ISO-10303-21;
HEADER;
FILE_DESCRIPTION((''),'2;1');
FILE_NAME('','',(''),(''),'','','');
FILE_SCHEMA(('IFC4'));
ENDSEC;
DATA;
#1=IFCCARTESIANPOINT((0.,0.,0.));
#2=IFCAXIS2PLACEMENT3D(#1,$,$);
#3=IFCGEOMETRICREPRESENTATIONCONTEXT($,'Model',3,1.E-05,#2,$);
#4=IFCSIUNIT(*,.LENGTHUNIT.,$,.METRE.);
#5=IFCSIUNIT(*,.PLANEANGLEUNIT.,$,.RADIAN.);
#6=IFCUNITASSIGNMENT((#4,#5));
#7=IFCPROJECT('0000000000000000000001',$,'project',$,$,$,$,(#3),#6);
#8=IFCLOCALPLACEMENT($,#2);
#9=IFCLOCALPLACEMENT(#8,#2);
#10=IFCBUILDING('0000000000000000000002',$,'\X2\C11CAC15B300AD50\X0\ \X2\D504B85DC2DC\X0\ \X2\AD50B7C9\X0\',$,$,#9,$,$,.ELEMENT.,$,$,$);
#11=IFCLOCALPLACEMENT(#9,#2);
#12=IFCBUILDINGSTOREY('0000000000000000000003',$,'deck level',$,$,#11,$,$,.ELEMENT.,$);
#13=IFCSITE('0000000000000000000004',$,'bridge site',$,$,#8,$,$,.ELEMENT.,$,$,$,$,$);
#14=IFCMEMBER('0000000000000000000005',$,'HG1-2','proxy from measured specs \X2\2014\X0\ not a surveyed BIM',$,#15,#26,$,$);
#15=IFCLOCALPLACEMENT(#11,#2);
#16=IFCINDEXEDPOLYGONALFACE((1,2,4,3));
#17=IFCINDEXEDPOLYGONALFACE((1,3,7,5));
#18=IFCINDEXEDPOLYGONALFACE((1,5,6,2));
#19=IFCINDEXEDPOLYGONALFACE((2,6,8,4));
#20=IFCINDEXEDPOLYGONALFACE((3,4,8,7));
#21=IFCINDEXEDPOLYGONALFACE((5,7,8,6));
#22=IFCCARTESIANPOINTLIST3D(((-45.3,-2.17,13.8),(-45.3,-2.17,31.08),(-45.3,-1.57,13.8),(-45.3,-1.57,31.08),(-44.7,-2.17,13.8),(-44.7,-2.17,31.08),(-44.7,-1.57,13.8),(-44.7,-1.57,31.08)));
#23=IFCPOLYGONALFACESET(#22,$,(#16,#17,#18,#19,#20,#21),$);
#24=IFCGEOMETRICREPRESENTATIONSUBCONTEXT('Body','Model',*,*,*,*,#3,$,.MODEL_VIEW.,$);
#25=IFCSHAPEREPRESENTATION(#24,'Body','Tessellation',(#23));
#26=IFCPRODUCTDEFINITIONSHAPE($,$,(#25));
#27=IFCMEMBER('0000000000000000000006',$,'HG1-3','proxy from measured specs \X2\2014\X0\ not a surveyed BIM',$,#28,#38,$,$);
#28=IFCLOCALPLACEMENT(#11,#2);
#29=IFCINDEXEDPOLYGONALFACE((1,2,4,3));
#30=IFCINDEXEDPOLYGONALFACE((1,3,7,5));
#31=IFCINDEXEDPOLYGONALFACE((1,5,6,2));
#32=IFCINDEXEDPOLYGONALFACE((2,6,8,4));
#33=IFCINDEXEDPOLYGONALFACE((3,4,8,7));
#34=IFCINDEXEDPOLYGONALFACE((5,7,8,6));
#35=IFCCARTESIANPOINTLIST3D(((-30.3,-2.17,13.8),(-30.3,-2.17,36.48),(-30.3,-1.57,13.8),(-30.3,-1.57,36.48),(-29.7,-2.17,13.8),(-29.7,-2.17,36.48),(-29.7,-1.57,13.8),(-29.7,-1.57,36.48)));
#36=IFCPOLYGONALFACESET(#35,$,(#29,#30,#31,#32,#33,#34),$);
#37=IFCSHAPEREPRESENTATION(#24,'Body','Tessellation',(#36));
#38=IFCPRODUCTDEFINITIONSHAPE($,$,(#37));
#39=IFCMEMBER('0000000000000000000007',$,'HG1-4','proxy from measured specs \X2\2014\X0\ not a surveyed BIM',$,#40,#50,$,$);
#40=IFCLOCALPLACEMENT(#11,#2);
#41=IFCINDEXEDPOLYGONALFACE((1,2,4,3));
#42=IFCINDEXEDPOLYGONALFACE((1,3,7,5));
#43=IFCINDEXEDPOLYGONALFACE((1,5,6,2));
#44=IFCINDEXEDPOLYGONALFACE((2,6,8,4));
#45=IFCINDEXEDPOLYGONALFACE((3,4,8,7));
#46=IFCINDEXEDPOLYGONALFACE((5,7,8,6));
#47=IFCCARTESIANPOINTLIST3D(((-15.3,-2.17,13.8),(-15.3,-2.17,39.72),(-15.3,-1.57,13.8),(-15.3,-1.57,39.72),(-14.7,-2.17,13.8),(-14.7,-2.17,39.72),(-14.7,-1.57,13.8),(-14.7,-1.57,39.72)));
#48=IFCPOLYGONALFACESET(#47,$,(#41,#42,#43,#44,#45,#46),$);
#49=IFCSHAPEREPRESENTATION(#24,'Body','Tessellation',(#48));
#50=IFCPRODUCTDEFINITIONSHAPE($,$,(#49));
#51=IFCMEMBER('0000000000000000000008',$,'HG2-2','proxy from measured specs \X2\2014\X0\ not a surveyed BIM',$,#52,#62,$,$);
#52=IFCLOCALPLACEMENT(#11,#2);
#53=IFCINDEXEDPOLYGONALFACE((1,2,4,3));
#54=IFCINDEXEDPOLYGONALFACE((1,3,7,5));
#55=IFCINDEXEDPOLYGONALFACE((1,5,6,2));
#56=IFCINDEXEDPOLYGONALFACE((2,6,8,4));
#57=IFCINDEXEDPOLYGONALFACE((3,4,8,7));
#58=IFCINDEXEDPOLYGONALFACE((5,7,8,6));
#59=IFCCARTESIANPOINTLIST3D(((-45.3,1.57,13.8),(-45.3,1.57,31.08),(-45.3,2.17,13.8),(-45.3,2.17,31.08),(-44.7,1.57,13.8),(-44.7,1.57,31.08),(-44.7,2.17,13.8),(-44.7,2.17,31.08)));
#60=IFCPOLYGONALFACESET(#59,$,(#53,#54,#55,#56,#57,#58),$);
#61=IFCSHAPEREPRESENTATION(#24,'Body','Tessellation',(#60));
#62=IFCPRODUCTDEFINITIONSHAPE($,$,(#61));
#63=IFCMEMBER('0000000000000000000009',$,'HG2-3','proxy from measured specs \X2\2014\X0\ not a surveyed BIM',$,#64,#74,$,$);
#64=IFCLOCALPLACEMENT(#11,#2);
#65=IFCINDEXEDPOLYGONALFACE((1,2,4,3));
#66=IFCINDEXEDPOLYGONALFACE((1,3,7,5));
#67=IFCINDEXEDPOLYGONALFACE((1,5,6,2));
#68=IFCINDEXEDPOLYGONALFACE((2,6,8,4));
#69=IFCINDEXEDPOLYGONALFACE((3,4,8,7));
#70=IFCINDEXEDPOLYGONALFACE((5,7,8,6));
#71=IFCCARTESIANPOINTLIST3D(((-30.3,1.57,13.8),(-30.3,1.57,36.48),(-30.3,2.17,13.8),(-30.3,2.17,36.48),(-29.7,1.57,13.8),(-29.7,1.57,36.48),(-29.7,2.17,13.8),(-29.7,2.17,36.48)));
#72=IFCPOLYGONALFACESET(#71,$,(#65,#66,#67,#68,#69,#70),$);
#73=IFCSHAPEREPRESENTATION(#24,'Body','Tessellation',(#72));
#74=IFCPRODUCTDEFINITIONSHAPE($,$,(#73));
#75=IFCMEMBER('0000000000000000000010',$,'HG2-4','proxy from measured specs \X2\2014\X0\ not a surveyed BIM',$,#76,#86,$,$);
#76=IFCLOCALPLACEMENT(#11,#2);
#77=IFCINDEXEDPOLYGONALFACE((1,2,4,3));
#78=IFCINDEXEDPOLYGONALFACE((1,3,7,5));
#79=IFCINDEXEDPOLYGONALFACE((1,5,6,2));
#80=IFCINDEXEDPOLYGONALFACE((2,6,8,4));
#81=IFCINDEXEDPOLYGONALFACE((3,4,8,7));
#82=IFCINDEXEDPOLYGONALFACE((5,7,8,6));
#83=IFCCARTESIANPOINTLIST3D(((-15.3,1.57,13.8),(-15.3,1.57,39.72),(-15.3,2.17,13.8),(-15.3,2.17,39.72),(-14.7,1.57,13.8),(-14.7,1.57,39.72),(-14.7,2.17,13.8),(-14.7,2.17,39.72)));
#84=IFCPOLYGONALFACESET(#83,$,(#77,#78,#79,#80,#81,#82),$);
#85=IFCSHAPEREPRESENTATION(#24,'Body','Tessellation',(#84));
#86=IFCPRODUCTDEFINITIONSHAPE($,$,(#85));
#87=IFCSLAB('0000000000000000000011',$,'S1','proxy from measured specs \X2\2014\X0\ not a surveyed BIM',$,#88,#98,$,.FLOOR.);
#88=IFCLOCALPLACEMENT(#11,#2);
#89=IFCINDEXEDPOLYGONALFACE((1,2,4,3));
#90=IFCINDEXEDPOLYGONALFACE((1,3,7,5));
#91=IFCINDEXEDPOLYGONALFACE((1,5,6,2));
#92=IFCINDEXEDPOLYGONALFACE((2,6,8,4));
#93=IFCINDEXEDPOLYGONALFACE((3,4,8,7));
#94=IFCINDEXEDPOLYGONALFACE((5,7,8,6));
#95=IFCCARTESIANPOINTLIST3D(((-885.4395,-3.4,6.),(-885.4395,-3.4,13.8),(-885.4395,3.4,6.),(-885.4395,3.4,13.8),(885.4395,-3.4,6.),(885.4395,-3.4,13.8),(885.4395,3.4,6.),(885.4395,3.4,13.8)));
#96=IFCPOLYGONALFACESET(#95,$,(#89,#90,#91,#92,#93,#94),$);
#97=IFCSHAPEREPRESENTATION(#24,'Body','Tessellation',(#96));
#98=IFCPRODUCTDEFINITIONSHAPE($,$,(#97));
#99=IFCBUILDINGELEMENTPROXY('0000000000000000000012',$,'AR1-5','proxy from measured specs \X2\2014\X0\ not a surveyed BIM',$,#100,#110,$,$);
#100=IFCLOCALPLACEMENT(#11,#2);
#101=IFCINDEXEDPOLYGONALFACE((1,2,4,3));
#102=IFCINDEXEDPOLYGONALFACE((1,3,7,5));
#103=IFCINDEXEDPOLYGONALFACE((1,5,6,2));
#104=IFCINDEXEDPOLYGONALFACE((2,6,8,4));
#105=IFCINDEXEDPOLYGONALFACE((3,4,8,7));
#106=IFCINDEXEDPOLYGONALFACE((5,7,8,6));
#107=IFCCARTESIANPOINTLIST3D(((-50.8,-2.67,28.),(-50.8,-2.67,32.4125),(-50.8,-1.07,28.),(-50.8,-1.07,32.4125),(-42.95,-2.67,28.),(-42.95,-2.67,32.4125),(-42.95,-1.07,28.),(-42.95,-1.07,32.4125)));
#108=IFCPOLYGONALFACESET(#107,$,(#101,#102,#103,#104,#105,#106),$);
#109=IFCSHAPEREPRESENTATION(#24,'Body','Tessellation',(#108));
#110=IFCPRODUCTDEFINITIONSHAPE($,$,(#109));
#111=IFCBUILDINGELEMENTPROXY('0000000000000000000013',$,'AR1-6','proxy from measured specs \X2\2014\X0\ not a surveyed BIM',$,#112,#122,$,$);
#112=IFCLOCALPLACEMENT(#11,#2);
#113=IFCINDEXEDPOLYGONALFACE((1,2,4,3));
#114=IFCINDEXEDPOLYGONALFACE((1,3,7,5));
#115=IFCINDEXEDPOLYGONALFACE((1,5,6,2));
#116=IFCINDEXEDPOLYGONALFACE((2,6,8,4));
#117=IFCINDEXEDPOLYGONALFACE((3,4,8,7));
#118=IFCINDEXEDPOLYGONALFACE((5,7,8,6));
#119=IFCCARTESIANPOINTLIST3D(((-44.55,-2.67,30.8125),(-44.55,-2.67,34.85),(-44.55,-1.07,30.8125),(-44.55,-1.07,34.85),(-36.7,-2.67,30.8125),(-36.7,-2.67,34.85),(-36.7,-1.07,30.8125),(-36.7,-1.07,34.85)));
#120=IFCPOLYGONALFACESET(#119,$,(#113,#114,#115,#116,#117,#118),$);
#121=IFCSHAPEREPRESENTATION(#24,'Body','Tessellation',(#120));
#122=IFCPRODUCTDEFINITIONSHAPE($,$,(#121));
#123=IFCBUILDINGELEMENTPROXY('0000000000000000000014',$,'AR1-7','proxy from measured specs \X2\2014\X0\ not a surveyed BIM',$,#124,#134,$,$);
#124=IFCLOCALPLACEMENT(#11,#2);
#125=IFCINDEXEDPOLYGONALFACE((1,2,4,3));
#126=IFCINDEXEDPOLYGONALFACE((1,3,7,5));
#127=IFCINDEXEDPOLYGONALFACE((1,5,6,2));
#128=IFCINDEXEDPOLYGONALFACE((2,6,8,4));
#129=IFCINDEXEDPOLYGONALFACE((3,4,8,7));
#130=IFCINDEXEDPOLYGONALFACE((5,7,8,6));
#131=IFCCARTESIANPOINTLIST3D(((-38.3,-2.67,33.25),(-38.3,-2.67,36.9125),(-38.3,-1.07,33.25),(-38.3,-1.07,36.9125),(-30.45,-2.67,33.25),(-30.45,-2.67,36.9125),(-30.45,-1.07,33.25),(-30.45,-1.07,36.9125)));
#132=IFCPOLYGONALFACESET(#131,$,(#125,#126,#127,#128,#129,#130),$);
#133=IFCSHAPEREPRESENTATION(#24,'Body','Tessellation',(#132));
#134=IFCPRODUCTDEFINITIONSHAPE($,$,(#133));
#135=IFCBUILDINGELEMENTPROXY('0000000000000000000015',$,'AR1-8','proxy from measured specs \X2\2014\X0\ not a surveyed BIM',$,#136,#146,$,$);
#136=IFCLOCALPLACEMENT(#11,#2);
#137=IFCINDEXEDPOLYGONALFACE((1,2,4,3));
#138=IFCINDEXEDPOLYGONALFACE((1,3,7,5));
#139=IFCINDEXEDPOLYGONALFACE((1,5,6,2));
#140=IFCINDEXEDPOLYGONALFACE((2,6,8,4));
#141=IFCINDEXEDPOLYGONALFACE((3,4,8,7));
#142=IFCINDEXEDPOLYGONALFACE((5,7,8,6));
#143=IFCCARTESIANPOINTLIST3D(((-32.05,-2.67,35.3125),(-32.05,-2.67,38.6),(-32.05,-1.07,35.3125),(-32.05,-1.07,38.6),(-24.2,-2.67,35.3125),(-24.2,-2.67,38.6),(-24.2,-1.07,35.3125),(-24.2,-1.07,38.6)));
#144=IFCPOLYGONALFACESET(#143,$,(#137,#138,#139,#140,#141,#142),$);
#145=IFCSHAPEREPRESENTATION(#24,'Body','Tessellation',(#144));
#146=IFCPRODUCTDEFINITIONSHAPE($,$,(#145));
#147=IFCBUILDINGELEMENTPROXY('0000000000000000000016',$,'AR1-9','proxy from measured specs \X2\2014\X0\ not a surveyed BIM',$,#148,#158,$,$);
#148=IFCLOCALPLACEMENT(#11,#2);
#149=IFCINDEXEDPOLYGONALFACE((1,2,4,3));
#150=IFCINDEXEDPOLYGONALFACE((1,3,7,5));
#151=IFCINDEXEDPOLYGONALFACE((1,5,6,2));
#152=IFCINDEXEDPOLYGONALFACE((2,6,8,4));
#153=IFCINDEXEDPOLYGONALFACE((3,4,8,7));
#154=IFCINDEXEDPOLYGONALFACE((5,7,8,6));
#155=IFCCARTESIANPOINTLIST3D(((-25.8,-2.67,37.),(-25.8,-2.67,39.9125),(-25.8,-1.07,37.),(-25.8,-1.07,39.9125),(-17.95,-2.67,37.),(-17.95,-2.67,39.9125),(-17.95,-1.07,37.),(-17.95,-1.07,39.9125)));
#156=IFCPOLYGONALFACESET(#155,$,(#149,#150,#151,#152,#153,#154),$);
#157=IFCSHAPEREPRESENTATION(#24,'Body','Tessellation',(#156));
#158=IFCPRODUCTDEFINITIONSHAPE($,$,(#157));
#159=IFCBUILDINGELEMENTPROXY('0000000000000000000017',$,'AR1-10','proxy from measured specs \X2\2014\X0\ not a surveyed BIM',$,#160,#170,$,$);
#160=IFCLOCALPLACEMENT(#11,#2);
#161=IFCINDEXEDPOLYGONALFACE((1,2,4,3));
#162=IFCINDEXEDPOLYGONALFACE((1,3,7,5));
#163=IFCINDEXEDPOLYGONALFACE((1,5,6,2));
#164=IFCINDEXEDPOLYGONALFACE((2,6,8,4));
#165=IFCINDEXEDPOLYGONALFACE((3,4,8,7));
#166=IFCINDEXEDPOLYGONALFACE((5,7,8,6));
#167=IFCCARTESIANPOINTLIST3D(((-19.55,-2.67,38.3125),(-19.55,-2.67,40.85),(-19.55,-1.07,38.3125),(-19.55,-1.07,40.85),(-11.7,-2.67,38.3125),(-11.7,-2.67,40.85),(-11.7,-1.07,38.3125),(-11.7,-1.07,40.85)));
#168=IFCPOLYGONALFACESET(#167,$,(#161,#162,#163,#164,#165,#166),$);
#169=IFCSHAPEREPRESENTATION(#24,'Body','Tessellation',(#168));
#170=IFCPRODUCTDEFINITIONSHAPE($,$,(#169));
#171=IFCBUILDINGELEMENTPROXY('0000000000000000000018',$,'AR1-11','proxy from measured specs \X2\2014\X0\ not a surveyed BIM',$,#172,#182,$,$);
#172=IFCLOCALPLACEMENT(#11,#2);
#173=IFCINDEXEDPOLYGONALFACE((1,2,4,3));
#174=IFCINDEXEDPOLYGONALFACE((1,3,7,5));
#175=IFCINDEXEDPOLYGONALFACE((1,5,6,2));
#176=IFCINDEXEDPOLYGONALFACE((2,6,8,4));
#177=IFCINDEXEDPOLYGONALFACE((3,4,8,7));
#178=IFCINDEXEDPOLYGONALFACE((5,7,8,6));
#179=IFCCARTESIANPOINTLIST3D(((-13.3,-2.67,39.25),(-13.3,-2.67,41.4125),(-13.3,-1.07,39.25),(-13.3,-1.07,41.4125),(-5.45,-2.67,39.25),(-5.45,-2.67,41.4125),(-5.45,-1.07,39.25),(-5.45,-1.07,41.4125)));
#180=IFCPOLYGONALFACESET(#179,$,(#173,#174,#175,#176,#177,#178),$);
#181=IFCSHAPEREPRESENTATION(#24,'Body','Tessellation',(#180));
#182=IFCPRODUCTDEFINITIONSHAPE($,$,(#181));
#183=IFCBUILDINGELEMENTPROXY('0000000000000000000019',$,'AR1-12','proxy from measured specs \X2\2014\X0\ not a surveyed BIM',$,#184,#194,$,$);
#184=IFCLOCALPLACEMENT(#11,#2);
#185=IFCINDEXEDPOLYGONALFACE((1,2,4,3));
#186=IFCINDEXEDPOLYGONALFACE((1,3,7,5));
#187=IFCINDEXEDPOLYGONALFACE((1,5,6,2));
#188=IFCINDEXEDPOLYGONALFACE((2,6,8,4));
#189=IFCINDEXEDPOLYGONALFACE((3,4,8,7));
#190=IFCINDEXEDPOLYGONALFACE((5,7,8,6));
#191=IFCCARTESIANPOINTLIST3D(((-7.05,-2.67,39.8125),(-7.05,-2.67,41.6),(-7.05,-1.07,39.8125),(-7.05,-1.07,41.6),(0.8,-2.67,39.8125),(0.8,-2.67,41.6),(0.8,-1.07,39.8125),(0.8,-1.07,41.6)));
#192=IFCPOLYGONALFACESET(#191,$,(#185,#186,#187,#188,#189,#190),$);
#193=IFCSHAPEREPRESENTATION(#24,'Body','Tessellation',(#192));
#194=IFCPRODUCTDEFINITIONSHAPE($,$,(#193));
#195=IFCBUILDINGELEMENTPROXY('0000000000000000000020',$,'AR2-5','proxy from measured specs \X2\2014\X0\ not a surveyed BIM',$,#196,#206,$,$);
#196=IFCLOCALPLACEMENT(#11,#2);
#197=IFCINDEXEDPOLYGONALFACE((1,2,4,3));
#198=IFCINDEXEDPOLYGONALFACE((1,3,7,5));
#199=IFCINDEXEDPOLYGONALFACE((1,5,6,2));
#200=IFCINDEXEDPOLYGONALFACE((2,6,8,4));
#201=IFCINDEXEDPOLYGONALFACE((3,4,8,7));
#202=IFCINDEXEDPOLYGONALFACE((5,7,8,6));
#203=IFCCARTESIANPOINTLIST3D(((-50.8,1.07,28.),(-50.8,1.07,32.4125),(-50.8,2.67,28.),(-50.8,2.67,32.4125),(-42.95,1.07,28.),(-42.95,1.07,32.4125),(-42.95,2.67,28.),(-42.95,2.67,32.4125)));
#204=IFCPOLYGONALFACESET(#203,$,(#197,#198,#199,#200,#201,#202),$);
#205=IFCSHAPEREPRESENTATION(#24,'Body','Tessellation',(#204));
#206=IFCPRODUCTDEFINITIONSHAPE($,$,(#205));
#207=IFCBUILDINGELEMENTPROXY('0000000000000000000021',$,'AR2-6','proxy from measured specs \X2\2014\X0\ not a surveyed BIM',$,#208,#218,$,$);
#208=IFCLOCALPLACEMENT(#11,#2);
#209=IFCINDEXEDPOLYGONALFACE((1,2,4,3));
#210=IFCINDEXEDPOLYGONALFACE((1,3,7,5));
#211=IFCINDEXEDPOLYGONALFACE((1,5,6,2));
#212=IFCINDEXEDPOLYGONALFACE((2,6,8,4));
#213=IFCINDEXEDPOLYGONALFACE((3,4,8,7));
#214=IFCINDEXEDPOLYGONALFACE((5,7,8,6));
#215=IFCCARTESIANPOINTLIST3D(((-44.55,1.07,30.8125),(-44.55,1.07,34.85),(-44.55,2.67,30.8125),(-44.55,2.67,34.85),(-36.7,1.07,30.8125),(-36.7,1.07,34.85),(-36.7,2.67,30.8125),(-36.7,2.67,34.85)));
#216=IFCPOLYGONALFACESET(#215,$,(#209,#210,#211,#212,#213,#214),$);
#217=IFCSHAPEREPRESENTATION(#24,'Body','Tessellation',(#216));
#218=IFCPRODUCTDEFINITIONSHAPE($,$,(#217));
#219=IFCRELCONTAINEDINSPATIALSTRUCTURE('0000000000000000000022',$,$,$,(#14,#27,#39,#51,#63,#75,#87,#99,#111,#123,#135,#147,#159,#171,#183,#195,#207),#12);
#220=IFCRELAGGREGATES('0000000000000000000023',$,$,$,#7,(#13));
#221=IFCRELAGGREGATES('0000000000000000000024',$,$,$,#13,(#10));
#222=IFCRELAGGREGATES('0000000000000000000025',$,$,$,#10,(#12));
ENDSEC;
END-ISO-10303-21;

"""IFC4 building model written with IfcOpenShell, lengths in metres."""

from ifc_helpers import new_model, si_unit, frame, origin, origin_2d, place, context, subcontext, project, spatial, rectangle, extrude, element, save


model = new_model("IFC4")

# Units and contexts
model_context = context("Model", 3, precision=1e-05, world=origin())
body_context = subcontext(model_context, "Body", "Model", "MODEL_VIEW")
ifc_project = project(units=[si_unit("LENGTHUNIT", "METRE"), si_unit("PLANEANGLEUNIT", "RADIAN")], contexts=[model_context])

# Site, building, storey
site_placement = place(None, origin())
site = spatial("IfcSite", under=ifc_project, at=site_placement, Name="bridge site", CompositionType="ELEMENT")
building_placement = place(site_placement, origin())
building = spatial("IfcBuilding", under=site, at=building_placement, Name="서강대교 프록시 교량", CompositionType="ELEMENT")
storey_placement = place(building_placement, origin())
storey = spatial("IfcBuildingStorey", under=building, at=storey_placement, Name="deck level", CompositionType="ELEMENT")

# Members
member_1_placement = place(storey_placement, frame((-45.0, -1.87, 13.8)))
element("IfcMember", 1, at=member_1_placement, inside=storey, Name="HG1-2", Description="proxy from measured specs — not a surveyed BIM", context=body_context, shape_type="SweptSolid", body=[
    extrude(rectangle(XDim=0.6, YDim=0.6, at=origin_2d()), origin(), (0.0, 0.0, 1.0), 17.28),
])
member_2_placement = place(storey_placement, frame((-30.0, -1.87, 13.8)))
element("IfcMember", 2, at=member_2_placement, inside=storey, Name="HG1-3", Description="proxy from measured specs — not a surveyed BIM", context=body_context, shape_type="SweptSolid", body=[
    extrude(rectangle(XDim=0.6, YDim=0.6, at=origin_2d()), origin(), (0.0, 0.0, 1.0), 22.68),
])
member_3_placement = place(storey_placement, frame((-15.0, -1.87, 13.8)))
element("IfcMember", 3, at=member_3_placement, inside=storey, Name="HG1-4", Description="proxy from measured specs — not a surveyed BIM", context=body_context, shape_type="SweptSolid", body=[
    extrude(rectangle(XDim=0.6, YDim=0.6, at=origin_2d()), origin(), (0.0, 0.0, 1.0), 25.92),
])
member_4_placement = place(storey_placement, frame((-45.0, 1.87, 13.8)))
element("IfcMember", 4, at=member_4_placement, inside=storey, Name="HG2-2", Description="proxy from measured specs — not a surveyed BIM", context=body_context, shape_type="SweptSolid", body=[
    extrude(rectangle(XDim=0.6, YDim=0.6, at=origin_2d()), origin(), (0.0, 0.0, 1.0), 17.28),
])
member_5_placement = place(storey_placement, frame((-30.0, 1.87, 13.8)))
element("IfcMember", 5, at=member_5_placement, inside=storey, Name="HG2-3", Description="proxy from measured specs — not a surveyed BIM", context=body_context, shape_type="SweptSolid", body=[
    extrude(rectangle(XDim=0.6, YDim=0.6, at=origin_2d()), origin(), (0.0, 0.0, 1.0), 22.68),
])
member_6_placement = place(storey_placement, frame((-15.0, 1.87, 13.8)))
element("IfcMember", 6, at=member_6_placement, inside=storey, Name="HG2-4", Description="proxy from measured specs — not a surveyed BIM", context=body_context, shape_type="SweptSolid", body=[
    extrude(rectangle(XDim=0.6, YDim=0.6, at=origin_2d()), origin(), (0.0, 0.0, 1.0), 25.92),
])

# Slab
slab_placement = place(storey_placement, frame((0.0, 0.0, 6.0)))
element("IfcSlab", 7, at=slab_placement, inside=storey, Name="S1", Description="proxy from measured specs — not a surveyed BIM", PredefinedType="FLOOR", context=body_context, shape_type="SweptSolid", body=[
    extrude(rectangle(XDim=1770.8791, YDim=6.8, at=origin_2d()), origin(), (0.0, 0.0, 1.0), 7.8),
])

# Building element proxies
proxy_1_placement = place(storey_placement, frame((-46.875, -1.87, 28.0)))
element("IfcBuildingElementProxy", 8, at=proxy_1_placement, inside=storey, Name="AR1-5", Description="proxy from measured specs — not a surveyed BIM", context=body_context, shape_type="SweptSolid", body=[
    extrude(rectangle(XDim=7.85, YDim=1.6, at=origin_2d()), origin(), (0.0, 0.0, 1.0), 4.4125),
])
proxy_2_placement = place(storey_placement, frame((-40.625, -1.87, 30.8125)))
element("IfcBuildingElementProxy", 9, at=proxy_2_placement, inside=storey, Name="AR1-6", Description="proxy from measured specs — not a surveyed BIM", context=body_context, shape_type="SweptSolid", body=[
    extrude(rectangle(XDim=7.85, YDim=1.6, at=origin_2d()), origin(), (0.0, 0.0, 1.0), 4.0375),
])
proxy_3_placement = place(storey_placement, frame((-34.375, -1.87, 33.25)))
element("IfcBuildingElementProxy", 10, at=proxy_3_placement, inside=storey, Name="AR1-7", Description="proxy from measured specs — not a surveyed BIM", context=body_context, shape_type="SweptSolid", body=[
    extrude(rectangle(XDim=7.85, YDim=1.6, at=origin_2d()), origin(), (0.0, 0.0, 1.0), 3.6625),
])
proxy_4_placement = place(storey_placement, frame((-28.125, -1.87, 35.3125)))
element("IfcBuildingElementProxy", 11, at=proxy_4_placement, inside=storey, Name="AR1-8", Description="proxy from measured specs — not a surveyed BIM", context=body_context, shape_type="SweptSolid", body=[
    extrude(rectangle(XDim=7.85, YDim=1.6, at=origin_2d()), origin(), (0.0, 0.0, 1.0), 3.2875),
])
proxy_5_placement = place(storey_placement, frame((-21.875, -1.87, 37.0)))
element("IfcBuildingElementProxy", 12, at=proxy_5_placement, inside=storey, Name="AR1-9", Description="proxy from measured specs — not a surveyed BIM", context=body_context, shape_type="SweptSolid", body=[
    extrude(rectangle(XDim=7.85, YDim=1.6, at=origin_2d()), origin(), (0.0, 0.0, 1.0), 2.9125),
])
proxy_6_placement = place(storey_placement, frame((-15.625, -1.87, 38.3125)))
element("IfcBuildingElementProxy", 13, at=proxy_6_placement, inside=storey, Name="AR1-10", Description="proxy from measured specs — not a surveyed BIM", context=body_context, shape_type="SweptSolid", body=[
    extrude(rectangle(XDim=7.85, YDim=1.6, at=origin_2d()), origin(), (0.0, 0.0, 1.0), 2.5375),
])
proxy_7_placement = place(storey_placement, frame((-9.375, -1.87, 39.25)))
element("IfcBuildingElementProxy", 14, at=proxy_7_placement, inside=storey, Name="AR1-11", Description="proxy from measured specs — not a surveyed BIM", context=body_context, shape_type="SweptSolid", body=[
    extrude(rectangle(XDim=7.85, YDim=1.6, at=origin_2d()), origin(), (0.0, 0.0, 1.0), 2.1625),
])
proxy_8_placement = place(storey_placement, frame((-3.125, -1.87, 39.8125)))
element("IfcBuildingElementProxy", 15, at=proxy_8_placement, inside=storey, Name="AR1-12", Description="proxy from measured specs — not a surveyed BIM", context=body_context, shape_type="SweptSolid", body=[
    extrude(rectangle(XDim=7.85, YDim=1.6, at=origin_2d()), origin(), (0.0, 0.0, 1.0), 1.7875),
])
proxy_9_placement = place(storey_placement, frame((-46.875, 1.87, 28.0)))
element("IfcBuildingElementProxy", 16, at=proxy_9_placement, inside=storey, Name="AR2-5", Description="proxy from measured specs — not a surveyed BIM", context=body_context, shape_type="SweptSolid", body=[
    extrude(rectangle(XDim=7.85, YDim=1.6, at=origin_2d()), origin(), (0.0, 0.0, 1.0), 4.4125),
])
proxy_10_placement = place(storey_placement, frame((-40.625, 1.87, 30.8125)))
element("IfcBuildingElementProxy", 17, at=proxy_10_placement, inside=storey, Name="AR2-6", Description="proxy from measured specs — not a surveyed BIM", context=body_context, shape_type="SweptSolid", body=[
    extrude(rectangle(XDim=7.85, YDim=1.6, at=origin_2d()), origin(), (0.0, 0.0, 1.0), 4.0375),
])

save(model, "model.ifc")
